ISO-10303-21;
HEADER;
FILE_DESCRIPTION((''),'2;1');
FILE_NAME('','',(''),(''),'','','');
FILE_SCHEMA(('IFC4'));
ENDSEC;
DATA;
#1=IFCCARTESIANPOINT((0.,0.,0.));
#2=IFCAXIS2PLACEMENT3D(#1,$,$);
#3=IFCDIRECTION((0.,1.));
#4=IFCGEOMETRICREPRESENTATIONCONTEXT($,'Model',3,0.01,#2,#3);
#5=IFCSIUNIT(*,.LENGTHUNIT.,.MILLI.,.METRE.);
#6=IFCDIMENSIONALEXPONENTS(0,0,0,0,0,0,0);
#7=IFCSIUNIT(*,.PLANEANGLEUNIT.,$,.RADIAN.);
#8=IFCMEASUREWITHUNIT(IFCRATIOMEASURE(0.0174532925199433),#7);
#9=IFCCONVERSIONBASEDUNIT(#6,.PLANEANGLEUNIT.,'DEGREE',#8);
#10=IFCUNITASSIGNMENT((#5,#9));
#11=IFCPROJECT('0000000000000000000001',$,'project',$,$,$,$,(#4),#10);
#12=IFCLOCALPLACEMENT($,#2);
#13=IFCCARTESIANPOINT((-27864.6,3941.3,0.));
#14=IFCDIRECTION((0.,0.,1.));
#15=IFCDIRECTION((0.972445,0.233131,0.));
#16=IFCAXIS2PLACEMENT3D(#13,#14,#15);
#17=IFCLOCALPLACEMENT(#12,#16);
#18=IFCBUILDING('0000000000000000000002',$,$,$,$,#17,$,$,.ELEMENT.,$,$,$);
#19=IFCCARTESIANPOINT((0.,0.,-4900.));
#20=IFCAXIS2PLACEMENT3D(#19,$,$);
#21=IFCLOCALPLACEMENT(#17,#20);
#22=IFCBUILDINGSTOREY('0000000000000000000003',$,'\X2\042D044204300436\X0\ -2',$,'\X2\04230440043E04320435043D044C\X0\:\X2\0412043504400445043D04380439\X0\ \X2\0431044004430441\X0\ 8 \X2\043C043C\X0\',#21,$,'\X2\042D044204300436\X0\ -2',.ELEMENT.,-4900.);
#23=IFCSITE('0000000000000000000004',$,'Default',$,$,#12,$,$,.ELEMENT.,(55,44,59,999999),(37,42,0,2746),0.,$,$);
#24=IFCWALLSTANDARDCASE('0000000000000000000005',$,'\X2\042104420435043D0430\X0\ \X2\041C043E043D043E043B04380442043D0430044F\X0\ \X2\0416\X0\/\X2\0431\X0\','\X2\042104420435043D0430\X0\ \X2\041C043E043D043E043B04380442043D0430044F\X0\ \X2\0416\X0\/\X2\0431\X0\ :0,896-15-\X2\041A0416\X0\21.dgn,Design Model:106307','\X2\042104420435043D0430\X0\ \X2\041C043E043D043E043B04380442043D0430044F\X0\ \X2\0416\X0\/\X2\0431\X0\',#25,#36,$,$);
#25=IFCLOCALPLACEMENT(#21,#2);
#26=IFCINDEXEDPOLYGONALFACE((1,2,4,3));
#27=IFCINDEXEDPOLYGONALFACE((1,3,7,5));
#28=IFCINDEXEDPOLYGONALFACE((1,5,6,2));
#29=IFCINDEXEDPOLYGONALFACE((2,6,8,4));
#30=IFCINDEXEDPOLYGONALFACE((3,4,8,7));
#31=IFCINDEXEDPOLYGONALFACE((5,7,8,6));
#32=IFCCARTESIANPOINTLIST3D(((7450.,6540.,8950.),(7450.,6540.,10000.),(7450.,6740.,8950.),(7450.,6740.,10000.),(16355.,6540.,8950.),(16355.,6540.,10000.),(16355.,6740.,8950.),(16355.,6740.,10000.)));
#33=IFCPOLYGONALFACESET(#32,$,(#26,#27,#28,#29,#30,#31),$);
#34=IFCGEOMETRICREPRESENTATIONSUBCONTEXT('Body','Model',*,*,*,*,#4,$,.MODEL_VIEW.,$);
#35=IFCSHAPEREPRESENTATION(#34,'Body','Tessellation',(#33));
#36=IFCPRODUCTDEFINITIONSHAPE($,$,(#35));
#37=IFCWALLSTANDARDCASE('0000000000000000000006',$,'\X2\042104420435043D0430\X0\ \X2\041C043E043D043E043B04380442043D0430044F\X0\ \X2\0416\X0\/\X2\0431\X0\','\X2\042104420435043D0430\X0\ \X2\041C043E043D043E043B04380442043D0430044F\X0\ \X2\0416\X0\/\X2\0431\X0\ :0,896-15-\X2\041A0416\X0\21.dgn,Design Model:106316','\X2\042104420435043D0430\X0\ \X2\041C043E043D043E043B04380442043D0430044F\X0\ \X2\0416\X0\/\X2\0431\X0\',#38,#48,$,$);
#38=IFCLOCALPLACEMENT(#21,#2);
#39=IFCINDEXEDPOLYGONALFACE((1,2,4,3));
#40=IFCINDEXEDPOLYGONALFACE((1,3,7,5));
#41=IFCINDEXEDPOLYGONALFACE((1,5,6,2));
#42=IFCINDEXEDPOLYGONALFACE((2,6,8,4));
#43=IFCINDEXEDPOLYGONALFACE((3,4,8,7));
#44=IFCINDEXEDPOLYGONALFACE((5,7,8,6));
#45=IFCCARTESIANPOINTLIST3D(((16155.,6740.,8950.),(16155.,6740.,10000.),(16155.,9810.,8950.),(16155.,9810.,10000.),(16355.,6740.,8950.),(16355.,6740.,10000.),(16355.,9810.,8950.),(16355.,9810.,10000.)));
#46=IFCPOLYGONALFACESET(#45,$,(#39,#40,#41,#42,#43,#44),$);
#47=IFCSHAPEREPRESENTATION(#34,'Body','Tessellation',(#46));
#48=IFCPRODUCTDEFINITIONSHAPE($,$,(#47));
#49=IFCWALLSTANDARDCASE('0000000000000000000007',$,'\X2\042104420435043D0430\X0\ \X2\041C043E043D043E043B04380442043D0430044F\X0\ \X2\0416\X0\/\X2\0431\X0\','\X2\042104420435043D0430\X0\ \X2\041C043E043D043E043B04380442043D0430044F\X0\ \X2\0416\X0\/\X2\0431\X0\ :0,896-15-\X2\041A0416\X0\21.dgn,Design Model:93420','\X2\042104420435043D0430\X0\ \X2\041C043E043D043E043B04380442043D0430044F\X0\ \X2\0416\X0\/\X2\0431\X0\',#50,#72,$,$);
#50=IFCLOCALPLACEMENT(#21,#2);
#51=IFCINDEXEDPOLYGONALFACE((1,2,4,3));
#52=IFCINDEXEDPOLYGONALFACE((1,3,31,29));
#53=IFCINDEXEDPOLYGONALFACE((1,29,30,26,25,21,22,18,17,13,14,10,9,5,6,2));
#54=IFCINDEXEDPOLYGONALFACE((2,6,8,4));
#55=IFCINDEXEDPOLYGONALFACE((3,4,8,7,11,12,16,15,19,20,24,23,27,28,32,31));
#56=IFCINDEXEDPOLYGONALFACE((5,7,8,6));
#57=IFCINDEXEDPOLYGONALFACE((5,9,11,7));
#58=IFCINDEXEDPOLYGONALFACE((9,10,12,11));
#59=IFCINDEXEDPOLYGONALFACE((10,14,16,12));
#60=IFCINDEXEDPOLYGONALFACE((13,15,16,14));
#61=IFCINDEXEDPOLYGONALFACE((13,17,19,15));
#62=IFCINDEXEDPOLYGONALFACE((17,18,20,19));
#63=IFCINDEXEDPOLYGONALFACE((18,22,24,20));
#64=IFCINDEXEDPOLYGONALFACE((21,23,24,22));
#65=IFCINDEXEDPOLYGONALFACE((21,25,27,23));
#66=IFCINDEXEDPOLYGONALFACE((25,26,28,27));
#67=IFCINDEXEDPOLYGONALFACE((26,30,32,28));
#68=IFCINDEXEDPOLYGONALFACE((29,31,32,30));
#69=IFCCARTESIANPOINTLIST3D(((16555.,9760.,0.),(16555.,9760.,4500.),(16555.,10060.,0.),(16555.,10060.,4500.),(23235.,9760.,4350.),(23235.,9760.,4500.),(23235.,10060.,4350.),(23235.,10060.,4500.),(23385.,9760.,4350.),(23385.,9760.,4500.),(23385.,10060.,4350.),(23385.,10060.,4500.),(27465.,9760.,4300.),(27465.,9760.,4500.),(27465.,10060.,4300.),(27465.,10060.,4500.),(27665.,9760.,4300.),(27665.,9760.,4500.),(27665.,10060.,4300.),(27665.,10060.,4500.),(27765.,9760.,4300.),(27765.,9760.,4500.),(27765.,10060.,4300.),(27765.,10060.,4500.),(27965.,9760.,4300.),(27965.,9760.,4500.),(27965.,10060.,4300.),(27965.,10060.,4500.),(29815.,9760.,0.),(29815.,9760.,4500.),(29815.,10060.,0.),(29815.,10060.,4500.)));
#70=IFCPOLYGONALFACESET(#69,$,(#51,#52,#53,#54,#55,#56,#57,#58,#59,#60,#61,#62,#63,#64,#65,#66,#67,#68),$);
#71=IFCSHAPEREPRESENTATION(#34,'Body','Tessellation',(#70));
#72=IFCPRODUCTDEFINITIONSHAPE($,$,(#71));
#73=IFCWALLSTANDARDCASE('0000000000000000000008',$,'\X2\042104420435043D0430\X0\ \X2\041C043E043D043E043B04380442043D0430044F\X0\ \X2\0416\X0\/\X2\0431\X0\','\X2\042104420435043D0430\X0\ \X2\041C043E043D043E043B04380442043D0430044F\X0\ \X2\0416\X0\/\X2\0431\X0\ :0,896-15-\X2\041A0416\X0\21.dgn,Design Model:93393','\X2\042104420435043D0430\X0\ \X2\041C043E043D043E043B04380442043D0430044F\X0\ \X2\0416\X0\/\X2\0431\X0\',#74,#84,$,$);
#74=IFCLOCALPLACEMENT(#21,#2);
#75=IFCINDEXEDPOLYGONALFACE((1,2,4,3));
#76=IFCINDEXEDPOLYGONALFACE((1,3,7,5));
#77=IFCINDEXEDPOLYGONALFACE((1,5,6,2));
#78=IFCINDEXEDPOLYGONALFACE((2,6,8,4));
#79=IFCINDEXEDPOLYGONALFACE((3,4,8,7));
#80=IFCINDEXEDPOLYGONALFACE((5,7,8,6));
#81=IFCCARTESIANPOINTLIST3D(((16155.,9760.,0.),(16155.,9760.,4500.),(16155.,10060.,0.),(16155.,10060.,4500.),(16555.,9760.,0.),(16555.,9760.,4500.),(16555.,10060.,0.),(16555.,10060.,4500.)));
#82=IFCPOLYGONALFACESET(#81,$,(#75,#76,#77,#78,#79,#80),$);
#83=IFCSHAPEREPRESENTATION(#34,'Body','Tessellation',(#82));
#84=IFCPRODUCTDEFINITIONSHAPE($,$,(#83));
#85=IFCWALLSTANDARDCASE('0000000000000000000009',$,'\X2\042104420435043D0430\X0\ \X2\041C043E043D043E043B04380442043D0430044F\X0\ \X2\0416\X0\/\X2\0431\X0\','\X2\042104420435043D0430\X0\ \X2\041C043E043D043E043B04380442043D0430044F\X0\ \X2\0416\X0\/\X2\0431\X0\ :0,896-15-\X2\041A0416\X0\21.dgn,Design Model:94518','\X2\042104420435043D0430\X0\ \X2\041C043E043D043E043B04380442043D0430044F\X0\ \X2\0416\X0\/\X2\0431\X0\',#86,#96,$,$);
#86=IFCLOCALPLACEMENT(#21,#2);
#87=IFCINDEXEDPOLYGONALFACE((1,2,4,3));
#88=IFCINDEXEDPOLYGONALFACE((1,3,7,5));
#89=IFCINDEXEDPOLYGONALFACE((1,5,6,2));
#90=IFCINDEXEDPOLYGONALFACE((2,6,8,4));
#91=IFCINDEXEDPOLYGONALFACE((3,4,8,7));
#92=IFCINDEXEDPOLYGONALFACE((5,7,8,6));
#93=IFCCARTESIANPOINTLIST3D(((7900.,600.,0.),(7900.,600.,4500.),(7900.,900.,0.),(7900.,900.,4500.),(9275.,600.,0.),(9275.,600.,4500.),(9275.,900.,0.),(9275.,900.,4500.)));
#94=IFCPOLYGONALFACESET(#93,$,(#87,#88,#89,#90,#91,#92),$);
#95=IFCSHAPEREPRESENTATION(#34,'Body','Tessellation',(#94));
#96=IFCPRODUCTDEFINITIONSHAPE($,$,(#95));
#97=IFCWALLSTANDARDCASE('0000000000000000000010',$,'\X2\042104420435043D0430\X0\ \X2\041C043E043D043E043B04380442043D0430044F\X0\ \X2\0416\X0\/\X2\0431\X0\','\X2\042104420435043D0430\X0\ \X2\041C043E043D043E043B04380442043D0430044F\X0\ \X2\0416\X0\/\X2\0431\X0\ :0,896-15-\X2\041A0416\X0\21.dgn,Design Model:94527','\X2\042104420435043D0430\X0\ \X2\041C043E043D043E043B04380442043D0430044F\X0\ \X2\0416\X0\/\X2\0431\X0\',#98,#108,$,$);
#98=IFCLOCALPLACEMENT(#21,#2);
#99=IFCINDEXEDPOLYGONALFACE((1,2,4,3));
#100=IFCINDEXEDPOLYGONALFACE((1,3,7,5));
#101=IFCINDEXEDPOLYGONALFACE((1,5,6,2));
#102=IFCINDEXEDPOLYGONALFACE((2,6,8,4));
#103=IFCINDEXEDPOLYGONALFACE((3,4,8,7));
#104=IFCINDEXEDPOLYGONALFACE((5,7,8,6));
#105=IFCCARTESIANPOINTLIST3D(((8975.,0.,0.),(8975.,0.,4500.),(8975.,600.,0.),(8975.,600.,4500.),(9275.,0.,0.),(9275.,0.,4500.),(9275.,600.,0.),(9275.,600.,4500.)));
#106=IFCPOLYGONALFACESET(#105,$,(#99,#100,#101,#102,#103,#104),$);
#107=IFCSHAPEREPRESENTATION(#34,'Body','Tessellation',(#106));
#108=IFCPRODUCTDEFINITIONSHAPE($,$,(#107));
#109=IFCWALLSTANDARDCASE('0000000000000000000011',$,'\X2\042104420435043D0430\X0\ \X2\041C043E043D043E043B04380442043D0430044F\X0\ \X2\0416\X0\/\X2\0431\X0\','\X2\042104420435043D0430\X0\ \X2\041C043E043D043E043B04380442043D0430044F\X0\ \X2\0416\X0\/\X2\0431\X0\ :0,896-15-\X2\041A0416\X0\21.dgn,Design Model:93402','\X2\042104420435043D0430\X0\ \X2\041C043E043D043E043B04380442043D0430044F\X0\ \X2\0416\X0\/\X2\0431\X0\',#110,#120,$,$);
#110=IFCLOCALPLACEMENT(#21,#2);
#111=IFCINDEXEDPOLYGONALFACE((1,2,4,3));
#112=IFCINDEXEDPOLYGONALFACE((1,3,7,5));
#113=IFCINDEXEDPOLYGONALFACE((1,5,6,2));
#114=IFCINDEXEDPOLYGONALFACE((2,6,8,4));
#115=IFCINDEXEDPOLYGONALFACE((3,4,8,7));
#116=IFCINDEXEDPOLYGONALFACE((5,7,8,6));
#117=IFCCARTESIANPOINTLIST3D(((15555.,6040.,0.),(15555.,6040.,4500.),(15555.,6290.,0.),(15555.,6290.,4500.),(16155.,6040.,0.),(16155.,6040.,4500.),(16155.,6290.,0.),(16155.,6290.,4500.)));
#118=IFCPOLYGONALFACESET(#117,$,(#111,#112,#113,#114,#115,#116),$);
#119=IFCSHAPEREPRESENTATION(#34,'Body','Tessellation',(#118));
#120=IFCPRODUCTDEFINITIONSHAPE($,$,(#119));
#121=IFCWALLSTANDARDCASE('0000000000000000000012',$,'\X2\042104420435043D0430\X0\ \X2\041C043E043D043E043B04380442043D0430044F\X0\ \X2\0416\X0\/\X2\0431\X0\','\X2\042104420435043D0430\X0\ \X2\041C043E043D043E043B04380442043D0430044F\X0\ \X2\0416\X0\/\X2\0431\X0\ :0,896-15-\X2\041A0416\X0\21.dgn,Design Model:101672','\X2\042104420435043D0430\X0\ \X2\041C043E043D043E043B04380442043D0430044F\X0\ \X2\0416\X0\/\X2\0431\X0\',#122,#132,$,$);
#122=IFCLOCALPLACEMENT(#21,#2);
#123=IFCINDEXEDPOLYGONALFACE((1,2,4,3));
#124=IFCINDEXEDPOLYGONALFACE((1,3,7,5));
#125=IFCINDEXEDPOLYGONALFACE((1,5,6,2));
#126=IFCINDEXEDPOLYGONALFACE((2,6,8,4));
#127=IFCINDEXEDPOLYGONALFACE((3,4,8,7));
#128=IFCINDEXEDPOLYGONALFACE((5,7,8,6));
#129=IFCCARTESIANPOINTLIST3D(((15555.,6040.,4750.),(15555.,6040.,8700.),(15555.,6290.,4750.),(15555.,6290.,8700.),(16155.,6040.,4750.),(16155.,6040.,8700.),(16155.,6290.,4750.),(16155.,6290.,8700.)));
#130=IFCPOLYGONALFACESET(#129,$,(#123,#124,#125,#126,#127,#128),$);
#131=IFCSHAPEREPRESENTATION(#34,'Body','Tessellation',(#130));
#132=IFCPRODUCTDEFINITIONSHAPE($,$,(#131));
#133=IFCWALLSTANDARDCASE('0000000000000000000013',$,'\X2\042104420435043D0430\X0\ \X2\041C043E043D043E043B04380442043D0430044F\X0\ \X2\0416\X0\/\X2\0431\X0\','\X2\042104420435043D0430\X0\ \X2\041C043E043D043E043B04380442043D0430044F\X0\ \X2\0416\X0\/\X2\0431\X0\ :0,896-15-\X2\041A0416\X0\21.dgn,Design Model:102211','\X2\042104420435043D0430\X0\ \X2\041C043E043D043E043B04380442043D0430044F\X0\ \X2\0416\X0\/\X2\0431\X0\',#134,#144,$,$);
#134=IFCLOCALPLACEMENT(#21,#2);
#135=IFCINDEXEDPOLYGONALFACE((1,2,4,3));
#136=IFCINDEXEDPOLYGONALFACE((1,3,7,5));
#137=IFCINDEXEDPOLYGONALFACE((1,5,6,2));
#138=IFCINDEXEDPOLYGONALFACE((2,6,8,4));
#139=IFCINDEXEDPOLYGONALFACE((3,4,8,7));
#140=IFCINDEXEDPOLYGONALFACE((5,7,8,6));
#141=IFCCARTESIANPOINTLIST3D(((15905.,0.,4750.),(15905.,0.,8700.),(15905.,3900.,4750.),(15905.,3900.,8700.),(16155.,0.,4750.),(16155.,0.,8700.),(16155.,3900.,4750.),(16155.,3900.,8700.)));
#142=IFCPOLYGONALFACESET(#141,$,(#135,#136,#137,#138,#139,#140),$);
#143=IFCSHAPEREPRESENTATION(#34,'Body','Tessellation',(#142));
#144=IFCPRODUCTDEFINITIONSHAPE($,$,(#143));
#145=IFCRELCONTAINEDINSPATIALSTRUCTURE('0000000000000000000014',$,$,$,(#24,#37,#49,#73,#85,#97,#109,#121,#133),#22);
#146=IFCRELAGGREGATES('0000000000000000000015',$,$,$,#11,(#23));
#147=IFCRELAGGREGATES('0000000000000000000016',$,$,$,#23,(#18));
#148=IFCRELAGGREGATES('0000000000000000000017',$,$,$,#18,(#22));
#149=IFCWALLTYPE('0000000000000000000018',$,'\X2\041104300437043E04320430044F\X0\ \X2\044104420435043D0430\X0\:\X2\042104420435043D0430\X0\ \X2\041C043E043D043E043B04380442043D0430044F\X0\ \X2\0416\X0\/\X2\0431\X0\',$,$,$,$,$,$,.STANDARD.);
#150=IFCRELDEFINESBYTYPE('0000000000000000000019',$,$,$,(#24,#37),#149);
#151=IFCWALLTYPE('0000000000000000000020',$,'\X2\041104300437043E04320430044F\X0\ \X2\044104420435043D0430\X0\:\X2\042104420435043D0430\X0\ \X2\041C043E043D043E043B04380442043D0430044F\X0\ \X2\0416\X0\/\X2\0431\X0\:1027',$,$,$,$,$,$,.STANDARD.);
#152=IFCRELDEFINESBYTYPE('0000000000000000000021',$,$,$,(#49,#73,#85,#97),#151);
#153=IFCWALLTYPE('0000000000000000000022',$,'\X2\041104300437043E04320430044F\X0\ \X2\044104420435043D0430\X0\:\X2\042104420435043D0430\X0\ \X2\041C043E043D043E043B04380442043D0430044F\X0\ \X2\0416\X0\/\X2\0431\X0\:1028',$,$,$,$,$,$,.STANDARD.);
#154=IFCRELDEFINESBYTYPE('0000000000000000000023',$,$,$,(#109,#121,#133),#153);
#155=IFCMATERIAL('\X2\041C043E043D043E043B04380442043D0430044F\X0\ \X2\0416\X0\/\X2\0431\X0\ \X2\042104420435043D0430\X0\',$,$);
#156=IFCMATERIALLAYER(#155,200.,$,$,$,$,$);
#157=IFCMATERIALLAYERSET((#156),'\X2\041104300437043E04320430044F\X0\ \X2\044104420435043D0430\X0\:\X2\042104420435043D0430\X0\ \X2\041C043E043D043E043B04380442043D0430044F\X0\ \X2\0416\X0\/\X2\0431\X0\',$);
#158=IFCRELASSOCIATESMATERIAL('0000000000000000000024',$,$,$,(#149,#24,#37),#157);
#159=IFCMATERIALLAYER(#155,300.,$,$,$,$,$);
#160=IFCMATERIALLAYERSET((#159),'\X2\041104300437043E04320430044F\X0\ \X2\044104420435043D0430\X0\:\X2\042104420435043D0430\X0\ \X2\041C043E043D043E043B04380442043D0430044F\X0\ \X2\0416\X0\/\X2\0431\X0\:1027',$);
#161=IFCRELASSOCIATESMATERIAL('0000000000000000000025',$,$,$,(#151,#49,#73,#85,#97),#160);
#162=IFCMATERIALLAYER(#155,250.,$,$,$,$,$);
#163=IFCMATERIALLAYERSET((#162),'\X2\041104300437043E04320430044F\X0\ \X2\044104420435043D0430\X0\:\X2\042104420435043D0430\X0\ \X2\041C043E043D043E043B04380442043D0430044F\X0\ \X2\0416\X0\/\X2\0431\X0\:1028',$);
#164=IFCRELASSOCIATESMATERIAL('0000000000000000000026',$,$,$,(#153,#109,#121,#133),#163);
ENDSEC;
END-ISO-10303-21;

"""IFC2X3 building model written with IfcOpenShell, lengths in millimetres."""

from ifc_helpers import new_model, entity, si_unit, converted_unit, direction, frame, frame_2d, origin, origin_2d_with_axis, place, context, subcontext, project, spatial, rectangle, extrude, material, layer, layer_set, layer_usage, type_object, element, save


model = new_model("IFC2X3")

# Units and contexts
model_context = context("Model", 3, precision=0.01, world=origin(), true_north=direction((0.0, 1.0)))
body_context = subcontext(model_context, "Body", "Model", "MODEL_VIEW")
ifc_project = project(units=[si_unit("LENGTHUNIT", "METRE", prefix="MILLI"), converted_unit("PLANEANGLEUNIT", "DEGREE", entity("IfcRatioMeasure", 0.0174532925199433), si_unit("PLANEANGLEUNIT", "RADIAN"), dimensions=[0, 0, 0, 0, 0, 0, 0])], contexts=[model_context])

# Site, building, storey
site_placement = place(None, origin())
site = spatial("IfcSite", under=ifc_project, at=site_placement, Name="Default", CompositionType="ELEMENT", RefLatitude=(55, 44, 59, 999999), RefLongitude=(37, 42, 0, 2746), RefElevation=0.0)
building_placement = place(site_placement, frame((-27864.6, 3941.3, 0.0), z_axis=(0.0, 0.0, 1.0), x_axis=(0.972445, 0.233131, 0.0)))
building = spatial("IfcBuilding", under=site, at=building_placement, CompositionType="ELEMENT")
storey_placement = place(building_placement, frame((0.0, 0.0, -4900.0)))
storey = spatial("IfcBuildingStorey", under=building, at=storey_placement, Name="Этаж -2", ObjectType="Уровень:Верхний брус 8 мм", LongName="Этаж -2", CompositionType="ELEMENT", Elevation=-4900.0)

# Shared definitions
ifc_material = material(Name="Монолитная Ж/б Стена")
ifc_layer_1 = layer(ifc_material, 200.0)
ifc_layer_set_1 = layer_set([ifc_layer_1], Name="Базовая стена:Стена Монолитная Ж/б")
ifc_layer_usage_1 = layer_usage(ifc_layer_set_1, "AXIS2", "NEGATIVE", 100.0)
wall_type_1 = type_object("IfcWallType", Name="Базовая стена:Стена Монолитная Ж/б", PredefinedType="STANDARD", material=ifc_layer_set_1)

# Walls
wall_1_placement = place(storey_placement, frame((16355.0, 6640.0, 8950.0), z_axis=(0.0, 0.0, 1.0), x_axis=(-1.0, 0.0, 0.0)))
element("IfcWallStandardCase", 1, at=wall_1_placement, inside=storey, type_object=wall_type_1, material=ifc_layer_usage_1, Name="Стена Монолитная Ж/б", Description="Стена Монолитная Ж/б :0,896-15-КЖ21.dgn,Design Model:106307", ObjectType="Стена Монолитная Ж/б", context=body_context, shape_type="SweptSolid", body=[
    extrude(rectangle(XDim=8905.0, YDim=200.0, at=frame_2d((4452.5, 0.0), x_axis=(-1.0, 0.0))), origin(), (0.0, 0.0, 1.0), 1050.0),
])
wall_2_placement = place(storey_placement, frame((16255.0, 9810.0, 8950.0), z_axis=(0.0, 0.0, 1.0), x_axis=(0.0, -1.0, 0.0)))
element("IfcWallStandardCase", 2, at=wall_2_placement, inside=storey, type_object=wall_type_1, material=ifc_layer_usage_1, Name="Стена Монолитная Ж/б", Description="Стена Монолитная Ж/б :0,896-15-КЖ21.dgn,Design Model:106316", ObjectType="Стена Монолитная Ж/б", context=body_context, shape_type="SweptSolid", body=[
    extrude(rectangle(XDim=3070.0, YDim=200.0, at=frame_2d((1535.0, 0.0), x_axis=(-1.0, 0.0))), origin(), (0.0, 0.0, 1.0), 1050.0),
])

# Wall, openings
ifc_layer_2 = layer(ifc_material, 300.0)
ifc_layer_set_2 = layer_set([ifc_layer_2], Name="Базовая стена:Стена Монолитная Ж/б:1027")
ifc_layer_usage_2 = layer_usage(ifc_layer_set_2, "AXIS2", "NEGATIVE", 150.0)
wall_type_2 = type_object("IfcWallType", Name="Базовая стена:Стена Монолитная Ж/б:1027", PredefinedType="STANDARD", material=ifc_layer_set_2)
wall_3_placement = place(storey_placement, frame((16555.0, 9910.0, 0.0)))
wall_3 = element("IfcWallStandardCase", 3, at=wall_3_placement, inside=storey, type_object=wall_type_2, material=ifc_layer_usage_2, Name="Стена Монолитная Ж/б", Description="Стена Монолитная Ж/б :0,896-15-КЖ21.dgn,Design Model:93420", ObjectType="Стена Монолитная Ж/б", context=body_context, shape_type="SweptSolid", body=[
    extrude(rectangle(XDim=13260.0, YDim=300.0, at=frame_2d((6630.0, 0.0), x_axis=(-1.0, 0.0))), origin(), (0.0, 0.0, 1.0), 4500.0),
])
placement_1 = place(wall_3_placement, origin())
element("IfcOpeningElement", 4, at=placement_1, cuts=wall_3, ObjectType="Opening", context=body_context, shape_type="SweptSolid", body=[
    extrude(rectangle(XDim=150.0, YDim=150.0, at=origin_2d_with_axis()), frame((6755.0, -150.0, 4425.0), z_axis=(0.0, 1.0, 0.0), x_axis=(0.0, 0.0, -1.0)), (0.0, 0.0, 1.0), 300.0),
])
element("IfcOpeningElement", 5, at=placement_1, cuts=wall_3, ObjectType="Opening", context=body_context, shape_type="SweptSolid", body=[
    extrude(rectangle(XDim=200.0, YDim=200.0, at=origin_2d_with_axis()), frame((11010.0, -150.0, 4400.0), z_axis=(0.0, 1.0, 0.0), x_axis=(0.0, 0.0, -1.0)), (0.0, 0.0, 1.0), 300.0),
])
element("IfcOpeningElement", 6, at=placement_1, cuts=wall_3, ObjectType="Opening", context=body_context, shape_type="SweptSolid", body=[
    extrude(rectangle(XDim=200.0, YDim=200.0, at=origin_2d_with_axis()), frame((11310.0, -150.0, 4400.0), z_axis=(0.0, 1.0, 0.0), x_axis=(0.0, 0.0, -1.0)), (0.0, 0.0, 1.0), 300.0),
])

# Walls
wall_4_placement = place(storey_placement, frame((16155.0, 9910.0, 0.0)))
element("IfcWallStandardCase", 7, at=wall_4_placement, inside=storey, type_object=wall_type_2, material=ifc_layer_usage_2, Name="Стена Монолитная Ж/б", Description="Стена Монолитная Ж/б :0,896-15-КЖ21.dgn,Design Model:93393", ObjectType="Стена Монолитная Ж/б", context=body_context, shape_type="SweptSolid", body=[
    extrude(rectangle(XDim=400.0, YDim=300.0, at=frame_2d((200.0, 0.0), x_axis=(-1.0, 0.0))), origin(), (0.0, 0.0, 1.0), 4500.0),
])
wall_5_placement = place(storey_placement, frame((9275.0, 750.0, 0.0), z_axis=(0.0, 0.0, 1.0), x_axis=(-1.0, 0.0, 0.0)))
element("IfcWallStandardCase", 8, at=wall_5_placement, inside=storey, type_object=wall_type_2, material=ifc_layer_usage_2, Name="Стена Монолитная Ж/б", Description="Стена Монолитная Ж/б :0,896-15-КЖ21.dgn,Design Model:94518", ObjectType="Стена Монолитная Ж/б", context=body_context, shape_type="SweptSolid", body=[
    extrude(rectangle(XDim=1375.0, YDim=300.0, at=frame_2d((687.5, 0.0), x_axis=(-1.0, 0.0))), origin(), (0.0, 0.0, 1.0), 4500.0),
])
wall_6_placement = place(storey_placement, frame((9125.0, 0.0, 0.0), z_axis=(0.0, 0.0, 1.0), x_axis=(0.0, 1.0, 0.0)))
element("IfcWallStandardCase", 9, at=wall_6_placement, inside=storey, type_object=wall_type_2, material=ifc_layer_usage_2, Name="Стена Монолитная Ж/б", Description="Стена Монолитная Ж/б :0,896-15-КЖ21.dgn,Design Model:94527", ObjectType="Стена Монолитная Ж/б", context=body_context, shape_type="SweptSolid", body=[
    extrude(rectangle(XDim=600.0, YDim=300.0, at=frame_2d((300.0, 0.0), x_axis=(-1.0, 0.0))), origin(), (0.0, 0.0, 1.0), 4500.0),
])
ifc_layer_3 = layer(ifc_material, 250.0)
ifc_layer_set_3 = layer_set([ifc_layer_3], Name="Базовая стена:Стена Монолитная Ж/б:1028")
ifc_layer_usage_3 = layer_usage(ifc_layer_set_3, "AXIS2", "NEGATIVE", 125.0)
wall_type_3 = type_object("IfcWallType", Name="Базовая стена:Стена Монолитная Ж/б:1028", PredefinedType="STANDARD", material=ifc_layer_set_3)
wall_7_placement = place(storey_placement, frame((16155.0, 6165.0, 0.0), z_axis=(0.0, 0.0, 1.0), x_axis=(-1.0, 0.0, 0.0)))
element("IfcWallStandardCase", 10, at=wall_7_placement, inside=storey, type_object=wall_type_3, material=ifc_layer_usage_3, Name="Стена Монолитная Ж/б", Description="Стена Монолитная Ж/б :0,896-15-КЖ21.dgn,Design Model:93402", ObjectType="Стена Монолитная Ж/б", context=body_context, shape_type="SweptSolid", body=[
    extrude(rectangle(XDim=600.0, YDim=250.0, at=frame_2d((300.0, 0.0), x_axis=(-1.0, 0.0))), origin(), (0.0, 0.0, 1.0), 4500.0),
])
wall_8_placement = place(storey_placement, frame((16155.0, 6165.0, 4750.0), z_axis=(0.0, 0.0, 1.0), x_axis=(-1.0, 0.0, 0.0)))
element("IfcWallStandardCase", 11, at=wall_8_placement, inside=storey, type_object=wall_type_3, material=ifc_layer_usage_3, Name="Стена Монолитная Ж/б", Description="Стена Монолитная Ж/б :0,896-15-КЖ21.dgn,Design Model:101672", ObjectType="Стена Монолитная Ж/б", context=body_context, shape_type="SweptSolid", body=[
    extrude(rectangle(XDim=600.0, YDim=250.0, at=frame_2d((300.0, 0.0), x_axis=(-1.0, 0.0))), origin(), (0.0, 0.0, 1.0), 3950.0),
])
wall_9_placement = place(storey_placement, frame((16030.0, 3900.0, 4750.0), z_axis=(0.0, 0.0, 1.0), x_axis=(0.0, -1.0, 0.0)))
element("IfcWallStandardCase", 12, at=wall_9_placement, inside=storey, type_object=wall_type_3, material=ifc_layer_usage_3, Name="Стена Монолитная Ж/б", Description="Стена Монолитная Ж/б :0,896-15-КЖ21.dgn,Design Model:102211", ObjectType="Стена Монолитная Ж/б", context=body_context, shape_type="SweptSolid", body=[
    extrude(rectangle(XDim=3900.0, YDim=250.0, at=frame_2d((1950.0, 0.0), x_axis=(-1.0, 0.0))), origin(), (0.0, 0.0, 1.0), 3950.0),
])

save(model, "model.ifc")
